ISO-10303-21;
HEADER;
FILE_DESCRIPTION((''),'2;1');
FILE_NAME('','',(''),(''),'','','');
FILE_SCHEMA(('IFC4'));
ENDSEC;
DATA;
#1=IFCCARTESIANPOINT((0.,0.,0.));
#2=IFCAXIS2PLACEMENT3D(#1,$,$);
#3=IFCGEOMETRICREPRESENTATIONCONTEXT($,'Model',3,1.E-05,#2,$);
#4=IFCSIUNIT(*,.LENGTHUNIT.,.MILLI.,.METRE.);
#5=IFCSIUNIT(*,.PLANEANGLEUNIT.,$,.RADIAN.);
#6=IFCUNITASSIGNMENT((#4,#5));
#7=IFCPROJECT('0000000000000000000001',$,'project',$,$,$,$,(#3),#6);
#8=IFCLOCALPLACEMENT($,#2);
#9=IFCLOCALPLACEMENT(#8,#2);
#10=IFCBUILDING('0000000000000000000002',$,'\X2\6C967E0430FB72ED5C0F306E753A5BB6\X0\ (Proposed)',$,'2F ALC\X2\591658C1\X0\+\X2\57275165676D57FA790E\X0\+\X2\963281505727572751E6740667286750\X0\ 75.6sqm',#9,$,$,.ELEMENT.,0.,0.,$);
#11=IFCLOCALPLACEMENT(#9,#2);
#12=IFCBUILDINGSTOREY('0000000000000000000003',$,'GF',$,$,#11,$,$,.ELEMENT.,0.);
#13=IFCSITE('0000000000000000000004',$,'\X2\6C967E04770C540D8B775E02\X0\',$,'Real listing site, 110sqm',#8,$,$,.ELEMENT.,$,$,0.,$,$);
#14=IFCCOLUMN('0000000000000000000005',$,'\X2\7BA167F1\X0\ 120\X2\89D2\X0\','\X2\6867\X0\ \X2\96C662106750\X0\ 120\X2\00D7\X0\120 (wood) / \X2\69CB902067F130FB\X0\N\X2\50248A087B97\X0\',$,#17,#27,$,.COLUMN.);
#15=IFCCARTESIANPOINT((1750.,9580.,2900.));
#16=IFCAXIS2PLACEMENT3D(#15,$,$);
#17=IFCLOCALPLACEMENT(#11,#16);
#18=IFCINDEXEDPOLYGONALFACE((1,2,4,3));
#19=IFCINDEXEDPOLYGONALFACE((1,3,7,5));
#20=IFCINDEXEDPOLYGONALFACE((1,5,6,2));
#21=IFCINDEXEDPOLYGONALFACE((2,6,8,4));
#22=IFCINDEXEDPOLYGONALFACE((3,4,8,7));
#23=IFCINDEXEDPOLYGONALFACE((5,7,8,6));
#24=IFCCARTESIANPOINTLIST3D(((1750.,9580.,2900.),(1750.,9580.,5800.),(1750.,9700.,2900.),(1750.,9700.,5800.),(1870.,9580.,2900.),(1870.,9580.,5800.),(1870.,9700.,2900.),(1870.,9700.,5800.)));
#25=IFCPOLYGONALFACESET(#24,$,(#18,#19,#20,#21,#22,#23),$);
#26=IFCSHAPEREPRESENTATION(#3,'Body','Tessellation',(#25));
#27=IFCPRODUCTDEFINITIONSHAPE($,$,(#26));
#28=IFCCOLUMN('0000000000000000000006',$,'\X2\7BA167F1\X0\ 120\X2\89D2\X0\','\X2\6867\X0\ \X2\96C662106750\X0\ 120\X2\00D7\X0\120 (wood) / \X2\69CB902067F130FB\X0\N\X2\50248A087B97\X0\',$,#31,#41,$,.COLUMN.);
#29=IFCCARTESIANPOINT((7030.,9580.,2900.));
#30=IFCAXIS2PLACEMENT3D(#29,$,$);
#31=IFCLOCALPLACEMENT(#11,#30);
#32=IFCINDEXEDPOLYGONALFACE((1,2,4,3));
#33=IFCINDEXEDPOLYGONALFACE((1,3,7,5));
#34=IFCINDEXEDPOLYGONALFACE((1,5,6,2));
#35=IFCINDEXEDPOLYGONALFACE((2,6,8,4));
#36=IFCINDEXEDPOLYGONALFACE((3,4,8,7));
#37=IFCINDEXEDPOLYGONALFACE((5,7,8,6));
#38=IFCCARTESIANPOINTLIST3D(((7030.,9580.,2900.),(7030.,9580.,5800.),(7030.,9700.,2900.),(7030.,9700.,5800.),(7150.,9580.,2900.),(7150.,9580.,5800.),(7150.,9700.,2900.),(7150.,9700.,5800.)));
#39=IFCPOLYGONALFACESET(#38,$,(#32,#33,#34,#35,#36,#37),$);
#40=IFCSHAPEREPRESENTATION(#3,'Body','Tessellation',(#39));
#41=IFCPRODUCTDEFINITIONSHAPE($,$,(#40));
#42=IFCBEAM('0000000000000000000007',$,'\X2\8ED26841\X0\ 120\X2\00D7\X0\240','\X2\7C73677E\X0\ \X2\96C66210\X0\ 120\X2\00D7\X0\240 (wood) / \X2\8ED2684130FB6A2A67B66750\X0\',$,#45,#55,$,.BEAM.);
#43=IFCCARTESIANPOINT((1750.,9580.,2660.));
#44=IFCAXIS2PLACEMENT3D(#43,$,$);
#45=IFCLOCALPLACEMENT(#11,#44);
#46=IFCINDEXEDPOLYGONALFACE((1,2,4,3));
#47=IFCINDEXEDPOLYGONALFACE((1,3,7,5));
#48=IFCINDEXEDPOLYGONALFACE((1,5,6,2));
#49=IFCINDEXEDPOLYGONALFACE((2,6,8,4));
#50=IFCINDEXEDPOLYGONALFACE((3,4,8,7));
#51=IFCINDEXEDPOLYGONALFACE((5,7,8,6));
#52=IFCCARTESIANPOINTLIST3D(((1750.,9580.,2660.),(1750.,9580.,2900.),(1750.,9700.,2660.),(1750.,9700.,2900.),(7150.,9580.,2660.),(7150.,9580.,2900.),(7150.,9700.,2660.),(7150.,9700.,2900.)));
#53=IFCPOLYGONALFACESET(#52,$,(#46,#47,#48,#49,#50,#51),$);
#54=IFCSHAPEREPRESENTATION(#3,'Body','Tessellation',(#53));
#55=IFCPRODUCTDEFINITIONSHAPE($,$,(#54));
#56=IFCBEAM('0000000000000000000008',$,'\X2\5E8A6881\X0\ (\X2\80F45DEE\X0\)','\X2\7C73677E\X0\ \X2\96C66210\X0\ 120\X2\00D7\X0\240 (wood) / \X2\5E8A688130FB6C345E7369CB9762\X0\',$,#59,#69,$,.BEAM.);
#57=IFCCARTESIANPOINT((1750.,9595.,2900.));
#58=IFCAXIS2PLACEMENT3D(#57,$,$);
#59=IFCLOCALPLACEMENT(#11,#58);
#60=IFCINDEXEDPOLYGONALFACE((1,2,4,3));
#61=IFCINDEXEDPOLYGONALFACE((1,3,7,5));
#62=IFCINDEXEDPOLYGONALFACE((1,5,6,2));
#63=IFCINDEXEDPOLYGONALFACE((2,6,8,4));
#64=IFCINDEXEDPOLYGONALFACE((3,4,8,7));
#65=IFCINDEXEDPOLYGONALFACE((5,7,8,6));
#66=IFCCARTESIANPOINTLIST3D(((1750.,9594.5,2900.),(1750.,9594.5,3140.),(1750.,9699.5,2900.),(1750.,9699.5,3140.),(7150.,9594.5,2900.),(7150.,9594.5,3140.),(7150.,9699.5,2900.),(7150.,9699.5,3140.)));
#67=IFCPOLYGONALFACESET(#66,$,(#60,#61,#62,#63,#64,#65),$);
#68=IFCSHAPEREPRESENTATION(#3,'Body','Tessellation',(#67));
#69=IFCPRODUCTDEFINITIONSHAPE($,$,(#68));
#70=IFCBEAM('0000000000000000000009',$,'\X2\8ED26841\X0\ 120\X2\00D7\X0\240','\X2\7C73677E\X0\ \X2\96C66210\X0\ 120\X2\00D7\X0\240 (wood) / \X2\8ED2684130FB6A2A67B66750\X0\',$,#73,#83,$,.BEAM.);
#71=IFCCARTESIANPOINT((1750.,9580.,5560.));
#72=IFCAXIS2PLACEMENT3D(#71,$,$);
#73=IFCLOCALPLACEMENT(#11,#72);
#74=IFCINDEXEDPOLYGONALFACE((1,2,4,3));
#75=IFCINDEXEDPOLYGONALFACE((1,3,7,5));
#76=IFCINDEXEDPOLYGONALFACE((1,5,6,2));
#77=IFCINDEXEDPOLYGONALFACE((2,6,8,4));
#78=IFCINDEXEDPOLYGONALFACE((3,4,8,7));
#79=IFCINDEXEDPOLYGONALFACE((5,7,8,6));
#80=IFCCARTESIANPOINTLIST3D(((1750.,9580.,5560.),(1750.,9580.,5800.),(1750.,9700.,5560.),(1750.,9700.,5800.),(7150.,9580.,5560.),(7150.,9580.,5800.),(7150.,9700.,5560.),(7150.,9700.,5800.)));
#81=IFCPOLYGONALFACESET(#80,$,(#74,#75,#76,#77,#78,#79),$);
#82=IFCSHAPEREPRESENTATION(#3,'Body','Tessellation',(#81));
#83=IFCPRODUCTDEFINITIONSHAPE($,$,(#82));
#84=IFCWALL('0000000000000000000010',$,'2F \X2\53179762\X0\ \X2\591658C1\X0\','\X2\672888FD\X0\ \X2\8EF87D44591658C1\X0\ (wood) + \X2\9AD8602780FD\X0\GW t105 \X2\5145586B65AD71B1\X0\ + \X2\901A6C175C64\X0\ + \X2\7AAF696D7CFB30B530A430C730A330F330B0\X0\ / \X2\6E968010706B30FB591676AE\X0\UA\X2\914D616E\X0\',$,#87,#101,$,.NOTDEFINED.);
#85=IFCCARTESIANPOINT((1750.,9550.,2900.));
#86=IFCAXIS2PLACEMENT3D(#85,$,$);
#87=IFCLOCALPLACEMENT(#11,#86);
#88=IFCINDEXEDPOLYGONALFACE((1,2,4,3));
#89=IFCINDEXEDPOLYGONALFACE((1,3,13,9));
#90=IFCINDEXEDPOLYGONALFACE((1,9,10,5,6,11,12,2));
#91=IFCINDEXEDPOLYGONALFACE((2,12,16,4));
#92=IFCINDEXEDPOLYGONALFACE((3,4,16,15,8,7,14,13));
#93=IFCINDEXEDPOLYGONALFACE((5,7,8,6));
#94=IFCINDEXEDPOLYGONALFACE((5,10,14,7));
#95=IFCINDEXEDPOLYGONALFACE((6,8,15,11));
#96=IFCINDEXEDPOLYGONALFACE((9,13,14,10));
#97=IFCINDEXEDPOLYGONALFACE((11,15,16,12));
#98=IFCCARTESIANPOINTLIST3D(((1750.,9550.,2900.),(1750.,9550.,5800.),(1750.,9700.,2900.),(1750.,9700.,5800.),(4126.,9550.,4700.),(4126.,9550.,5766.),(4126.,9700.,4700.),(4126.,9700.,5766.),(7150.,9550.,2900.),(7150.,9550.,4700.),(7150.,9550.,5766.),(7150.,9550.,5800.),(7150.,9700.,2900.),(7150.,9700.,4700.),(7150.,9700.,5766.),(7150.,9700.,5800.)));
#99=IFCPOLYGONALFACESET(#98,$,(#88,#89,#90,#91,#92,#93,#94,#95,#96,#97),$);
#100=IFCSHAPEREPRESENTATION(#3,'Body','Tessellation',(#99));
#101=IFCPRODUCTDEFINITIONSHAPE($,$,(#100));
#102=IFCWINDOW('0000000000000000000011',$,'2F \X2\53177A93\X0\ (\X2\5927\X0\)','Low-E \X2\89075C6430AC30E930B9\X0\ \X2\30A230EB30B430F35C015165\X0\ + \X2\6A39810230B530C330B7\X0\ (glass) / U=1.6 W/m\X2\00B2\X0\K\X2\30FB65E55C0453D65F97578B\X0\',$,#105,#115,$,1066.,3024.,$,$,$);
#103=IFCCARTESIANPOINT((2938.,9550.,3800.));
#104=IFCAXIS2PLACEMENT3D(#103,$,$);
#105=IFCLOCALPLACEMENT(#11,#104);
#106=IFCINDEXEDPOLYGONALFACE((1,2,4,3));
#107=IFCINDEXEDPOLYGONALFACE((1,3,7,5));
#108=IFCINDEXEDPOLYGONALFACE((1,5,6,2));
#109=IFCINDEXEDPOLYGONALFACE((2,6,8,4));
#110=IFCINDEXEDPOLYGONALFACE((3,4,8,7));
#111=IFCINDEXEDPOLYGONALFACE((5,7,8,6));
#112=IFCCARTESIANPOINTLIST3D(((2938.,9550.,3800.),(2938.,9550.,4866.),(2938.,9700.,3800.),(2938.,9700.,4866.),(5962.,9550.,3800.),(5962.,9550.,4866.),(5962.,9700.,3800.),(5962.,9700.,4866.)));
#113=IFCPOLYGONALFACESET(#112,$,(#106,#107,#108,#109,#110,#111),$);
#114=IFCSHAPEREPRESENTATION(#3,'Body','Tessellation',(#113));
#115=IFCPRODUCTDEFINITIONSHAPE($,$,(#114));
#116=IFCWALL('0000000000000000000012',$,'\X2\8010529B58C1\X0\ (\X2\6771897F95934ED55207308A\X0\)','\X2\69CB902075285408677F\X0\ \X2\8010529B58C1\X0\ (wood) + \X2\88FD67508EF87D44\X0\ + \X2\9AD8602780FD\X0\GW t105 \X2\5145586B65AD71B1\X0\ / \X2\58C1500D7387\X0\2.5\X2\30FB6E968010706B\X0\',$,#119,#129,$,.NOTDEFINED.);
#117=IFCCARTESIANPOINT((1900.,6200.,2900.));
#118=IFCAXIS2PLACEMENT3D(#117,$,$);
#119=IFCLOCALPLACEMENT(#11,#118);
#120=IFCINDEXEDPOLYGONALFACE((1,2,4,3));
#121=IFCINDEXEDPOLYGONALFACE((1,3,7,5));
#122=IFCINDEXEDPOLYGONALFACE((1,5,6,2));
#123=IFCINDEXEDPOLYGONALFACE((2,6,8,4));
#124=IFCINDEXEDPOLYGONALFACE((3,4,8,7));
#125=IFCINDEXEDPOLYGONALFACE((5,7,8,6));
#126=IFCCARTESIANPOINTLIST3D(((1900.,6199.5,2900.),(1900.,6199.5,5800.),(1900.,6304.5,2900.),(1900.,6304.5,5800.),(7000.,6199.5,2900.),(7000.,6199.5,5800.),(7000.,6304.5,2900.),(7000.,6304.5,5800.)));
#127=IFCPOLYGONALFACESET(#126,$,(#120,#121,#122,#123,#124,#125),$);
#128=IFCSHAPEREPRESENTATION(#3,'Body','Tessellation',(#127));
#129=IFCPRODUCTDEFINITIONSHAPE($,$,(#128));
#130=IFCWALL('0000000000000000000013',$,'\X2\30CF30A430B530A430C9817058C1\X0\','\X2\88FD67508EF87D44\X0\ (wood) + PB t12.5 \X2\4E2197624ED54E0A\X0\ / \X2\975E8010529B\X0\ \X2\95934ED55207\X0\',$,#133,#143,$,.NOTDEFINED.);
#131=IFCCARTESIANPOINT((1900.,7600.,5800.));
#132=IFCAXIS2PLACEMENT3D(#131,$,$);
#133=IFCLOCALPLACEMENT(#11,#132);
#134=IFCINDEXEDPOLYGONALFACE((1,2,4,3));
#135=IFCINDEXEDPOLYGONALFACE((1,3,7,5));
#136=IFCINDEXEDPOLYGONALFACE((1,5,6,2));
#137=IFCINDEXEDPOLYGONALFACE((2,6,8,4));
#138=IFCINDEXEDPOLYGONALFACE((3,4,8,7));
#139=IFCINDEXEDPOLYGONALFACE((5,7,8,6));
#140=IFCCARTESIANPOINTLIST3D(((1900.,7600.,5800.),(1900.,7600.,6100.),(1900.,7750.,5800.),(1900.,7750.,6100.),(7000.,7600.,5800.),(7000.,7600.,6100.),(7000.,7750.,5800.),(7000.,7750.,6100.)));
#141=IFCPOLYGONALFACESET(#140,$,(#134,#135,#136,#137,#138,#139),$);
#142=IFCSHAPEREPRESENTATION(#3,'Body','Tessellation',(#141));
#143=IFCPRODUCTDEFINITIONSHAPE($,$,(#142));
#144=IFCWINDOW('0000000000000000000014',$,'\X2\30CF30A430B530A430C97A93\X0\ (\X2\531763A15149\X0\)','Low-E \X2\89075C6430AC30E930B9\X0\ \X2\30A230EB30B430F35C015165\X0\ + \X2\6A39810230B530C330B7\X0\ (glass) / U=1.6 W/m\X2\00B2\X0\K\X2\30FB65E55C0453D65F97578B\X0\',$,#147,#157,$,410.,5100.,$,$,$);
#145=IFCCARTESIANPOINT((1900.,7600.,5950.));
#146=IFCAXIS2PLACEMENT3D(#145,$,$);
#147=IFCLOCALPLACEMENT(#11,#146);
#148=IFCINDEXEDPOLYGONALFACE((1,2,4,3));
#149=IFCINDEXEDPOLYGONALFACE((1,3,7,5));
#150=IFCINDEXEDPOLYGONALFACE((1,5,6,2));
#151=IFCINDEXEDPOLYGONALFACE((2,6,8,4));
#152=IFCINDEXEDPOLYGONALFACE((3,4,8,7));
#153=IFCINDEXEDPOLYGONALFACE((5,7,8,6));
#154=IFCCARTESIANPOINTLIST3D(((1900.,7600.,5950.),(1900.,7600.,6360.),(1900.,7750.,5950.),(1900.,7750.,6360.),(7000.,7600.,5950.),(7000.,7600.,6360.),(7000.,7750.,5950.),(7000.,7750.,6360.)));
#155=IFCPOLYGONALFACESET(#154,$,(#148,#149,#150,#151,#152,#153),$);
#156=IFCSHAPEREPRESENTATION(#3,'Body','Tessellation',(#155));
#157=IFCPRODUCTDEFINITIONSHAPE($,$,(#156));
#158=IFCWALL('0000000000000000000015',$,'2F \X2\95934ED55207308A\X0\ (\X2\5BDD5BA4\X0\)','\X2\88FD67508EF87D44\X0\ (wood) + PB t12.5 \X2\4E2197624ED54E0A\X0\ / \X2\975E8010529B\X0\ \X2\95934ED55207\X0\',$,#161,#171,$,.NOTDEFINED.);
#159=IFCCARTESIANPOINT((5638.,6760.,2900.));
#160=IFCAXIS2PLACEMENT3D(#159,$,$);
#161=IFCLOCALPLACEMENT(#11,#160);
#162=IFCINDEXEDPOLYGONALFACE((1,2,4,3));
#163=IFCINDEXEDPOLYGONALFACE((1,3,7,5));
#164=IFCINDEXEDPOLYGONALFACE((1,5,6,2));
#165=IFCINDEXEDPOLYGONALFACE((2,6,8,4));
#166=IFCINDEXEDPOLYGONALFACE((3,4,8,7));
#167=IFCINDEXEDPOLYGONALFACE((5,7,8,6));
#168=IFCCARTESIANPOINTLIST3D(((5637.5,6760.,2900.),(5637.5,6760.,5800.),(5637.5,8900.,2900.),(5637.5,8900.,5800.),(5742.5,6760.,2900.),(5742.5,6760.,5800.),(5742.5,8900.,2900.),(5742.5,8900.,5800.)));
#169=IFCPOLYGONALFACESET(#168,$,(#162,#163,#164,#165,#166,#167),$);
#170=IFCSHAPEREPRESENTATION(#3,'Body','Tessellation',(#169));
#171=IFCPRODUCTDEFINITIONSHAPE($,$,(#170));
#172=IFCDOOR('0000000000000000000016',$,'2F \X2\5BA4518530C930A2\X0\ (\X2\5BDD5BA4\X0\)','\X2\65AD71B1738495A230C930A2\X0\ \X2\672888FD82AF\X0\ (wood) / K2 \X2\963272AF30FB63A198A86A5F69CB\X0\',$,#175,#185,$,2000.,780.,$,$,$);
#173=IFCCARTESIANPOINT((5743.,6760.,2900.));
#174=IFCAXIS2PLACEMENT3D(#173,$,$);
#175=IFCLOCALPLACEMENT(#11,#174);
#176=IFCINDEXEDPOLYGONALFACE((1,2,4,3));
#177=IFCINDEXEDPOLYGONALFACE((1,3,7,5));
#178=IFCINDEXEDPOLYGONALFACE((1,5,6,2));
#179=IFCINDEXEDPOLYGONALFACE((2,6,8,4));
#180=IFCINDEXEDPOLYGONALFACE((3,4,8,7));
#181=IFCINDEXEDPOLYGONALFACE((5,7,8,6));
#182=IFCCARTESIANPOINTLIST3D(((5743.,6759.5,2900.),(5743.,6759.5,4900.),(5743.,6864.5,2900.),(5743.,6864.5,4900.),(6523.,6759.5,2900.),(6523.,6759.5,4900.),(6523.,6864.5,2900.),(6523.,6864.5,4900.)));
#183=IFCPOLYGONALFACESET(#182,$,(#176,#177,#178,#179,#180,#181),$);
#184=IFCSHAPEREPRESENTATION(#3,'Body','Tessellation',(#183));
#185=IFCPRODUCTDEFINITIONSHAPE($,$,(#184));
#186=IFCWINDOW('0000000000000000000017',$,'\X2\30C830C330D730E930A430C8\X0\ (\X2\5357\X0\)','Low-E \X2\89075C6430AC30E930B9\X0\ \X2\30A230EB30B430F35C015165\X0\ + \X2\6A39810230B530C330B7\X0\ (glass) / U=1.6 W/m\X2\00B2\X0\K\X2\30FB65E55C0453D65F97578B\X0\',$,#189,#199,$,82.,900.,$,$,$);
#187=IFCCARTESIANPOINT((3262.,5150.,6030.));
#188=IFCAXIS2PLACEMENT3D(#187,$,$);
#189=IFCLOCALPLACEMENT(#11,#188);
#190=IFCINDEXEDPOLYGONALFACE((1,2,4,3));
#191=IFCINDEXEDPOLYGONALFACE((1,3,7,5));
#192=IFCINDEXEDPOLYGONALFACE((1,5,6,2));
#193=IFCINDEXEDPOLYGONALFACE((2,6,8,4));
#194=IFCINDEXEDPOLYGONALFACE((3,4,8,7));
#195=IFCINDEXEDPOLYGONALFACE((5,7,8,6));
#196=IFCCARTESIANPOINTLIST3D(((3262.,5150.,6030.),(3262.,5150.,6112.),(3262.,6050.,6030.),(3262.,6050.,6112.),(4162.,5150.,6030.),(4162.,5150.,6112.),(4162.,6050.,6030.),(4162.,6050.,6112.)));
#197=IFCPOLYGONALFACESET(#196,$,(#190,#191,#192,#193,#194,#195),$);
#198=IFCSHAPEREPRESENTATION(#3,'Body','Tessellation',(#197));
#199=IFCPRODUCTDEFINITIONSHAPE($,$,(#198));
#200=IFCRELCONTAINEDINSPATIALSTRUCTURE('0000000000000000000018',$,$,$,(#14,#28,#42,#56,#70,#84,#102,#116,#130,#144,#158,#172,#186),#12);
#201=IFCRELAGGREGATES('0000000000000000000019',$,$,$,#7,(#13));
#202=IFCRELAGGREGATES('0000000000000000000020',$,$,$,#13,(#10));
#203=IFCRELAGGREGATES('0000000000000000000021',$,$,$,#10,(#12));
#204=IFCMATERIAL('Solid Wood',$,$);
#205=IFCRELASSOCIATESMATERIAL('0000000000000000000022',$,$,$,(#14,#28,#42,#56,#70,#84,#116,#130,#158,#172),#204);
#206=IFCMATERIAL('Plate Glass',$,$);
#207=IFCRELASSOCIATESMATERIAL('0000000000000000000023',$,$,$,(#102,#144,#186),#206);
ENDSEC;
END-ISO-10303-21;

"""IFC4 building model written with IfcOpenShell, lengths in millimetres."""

from ifc_helpers import new_model, si_unit, frame, frame_2d, origin, place, context, project, spatial, rectangle, extrude, material, element, fill, save


model = new_model("IFC4")

# Units and contexts
model_context = context("Model", 3, precision=1e-05, world=origin())
ifc_project = project(units=[si_unit("LENGTHUNIT", "METRE", prefix="MILLI"), si_unit("PLANEANGLEUNIT", "RADIAN")], contexts=[model_context])

# Site, building, storey
site_placement = place(None, origin())
site = spatial("IfcSite", under=ifc_project, at=site_placement, Name="沖縄県名護市", ObjectType="Real listing site, 110sqm", CompositionType="ELEMENT", RefElevation=0.0)
building_placement = place(site_placement, origin())
building = spatial("IfcBuilding", under=site, at=building_placement, Name="沖縄・狭小の町家 (Proposed)", ObjectType="2F ALC外壁+圧入杭基礎+防腐圧圧処理木材 75.6sqm", CompositionType="ELEMENT", ElevationOfRefHeight=0.0, ElevationOfTerrain=0.0)
storey_placement = place(building_placement, origin())
storey = spatial("IfcBuildingStorey", under=building, at=storey_placement, Name="GF", CompositionType="ELEMENT", Elevation=0.0)

# Columns
ifc_material_1 = material(Name="Solid Wood")
column_1_placement = place(storey_placement, frame((1750.0, 9580.0, 2900.0)))
element("IfcColumn", 1, at=column_1_placement, inside=storey, material=ifc_material_1, Name="管柱 120角", Description="桧 集成材 120×120 (wood) / 構造柱・N値計算", PredefinedType="COLUMN", context=model_context, shape_type="SweptSolid", body=[
    extrude(rectangle(XDim=120.0, YDim=120.0, at=frame_2d((60.0, 60.0))), frame((1750.0, 9580.0, 2900.0)), (0.0, 0.0, 1.0), 2900.0),
])
column_2_placement = place(storey_placement, frame((7030.0, 9580.0, 2900.0)))
element("IfcColumn", 2, at=column_2_placement, inside=storey, material=ifc_material_1, Name="管柱 120角", Description="桧 集成材 120×120 (wood) / 構造柱・N値計算", PredefinedType="COLUMN", context=model_context, shape_type="SweptSolid", body=[
    extrude(rectangle(XDim=120.0, YDim=120.0, at=frame_2d((60.0, 60.0))), frame((7030.0, 9580.0, 2900.0)), (0.0, 0.0, 1.0), 2900.0),
])

# Beams
beam_1_placement = place(storey_placement, frame((1750.0, 9580.0, 2660.0)))
element("IfcBeam", 3, at=beam_1_placement, inside=storey, material=ifc_material_1, Name="軒桁 120×240", Description="米松 集成 120×240 (wood) / 軒桁・横架材", PredefinedType="BEAM", context=model_context, shape_type="SweptSolid", body=[
    extrude(rectangle(XDim=5400.0, YDim=120.0, at=frame_2d((2700.0, 60.0))), frame((1750.0, 9580.0, 2660.0)), (0.0, 0.0, 1.0), 240.0),
])
beam_2_placement = place(storey_placement, frame((1750.0, 9595.0, 2900.0)))
element("IfcBeam", 4, at=beam_2_placement, inside=storey, material=ifc_material_1, Name="床梁 (胴差)", Description="米松 集成 120×240 (wood) / 床梁・水平構面", PredefinedType="BEAM", context=model_context, shape_type="SweptSolid", body=[
    extrude(rectangle(XDim=5400.0, YDim=105.0, at=frame_2d((2700.0, 52.0))), frame((1750.0, 9595.0, 2900.0)), (0.0, 0.0, 1.0), 240.0),
])
beam_3_placement = place(storey_placement, frame((1750.0, 9580.0, 5560.0)))
element("IfcBeam", 5, at=beam_3_placement, inside=storey, material=ifc_material_1, Name="軒桁 120×240", Description="米松 集成 120×240 (wood) / 軒桁・横架材", PredefinedType="BEAM", context=model_context, shape_type="SweptSolid", body=[
    extrude(rectangle(XDim=5400.0, YDim=120.0, at=frame_2d((2700.0, 60.0))), frame((1750.0, 9580.0, 5560.0)), (0.0, 0.0, 1.0), 240.0),
])

# Wall, opening, window
wall_1_placement = place(storey_placement, frame((1750.0, 9550.0, 2900.0)))
wall_1 = element("IfcWall", 6, at=wall_1_placement, inside=storey, material=ifc_material_1, Name="2F 北面 外壁", Description="木製 軸組外壁 (wood) + 高性能GW t105 充填断熱 + 通気層 + 窯業系サイディング / 準耐火・外皮UA配慮", PredefinedType="NOTDEFINED", context=model_context, shape_type="SweptSolid", body=[
    extrude(rectangle(XDim=5400.0, YDim=150.0, at=frame_2d((2700.0, 75.0))), frame((1750.0, 9550.0, 2900.0)), (0.0, 0.0, 1.0), 2900.0),
])
opening_1_placement = place(storey_placement, frame((2938.0, 9550.0, 3800.0)))
opening_1 = element("IfcOpeningElement", 7, at=opening_1_placement, cuts=wall_1, PredefinedType="NOTDEFINED", context=model_context, shape_type="SweptSolid", body=[
    extrude(rectangle(XDim=3024.0, YDim=150.0, at=frame_2d((1512.0, 75.0))), frame((2938.0, 9550.0, 3800.0)), (0.0, 0.0, 1.0), 1066.0),
])
ifc_material_2 = material(Name="Plate Glass")
window_1_placement = place(storey_placement, frame((2938.0, 9550.0, 3800.0)))
window_1 = element("IfcWindow", 8, at=window_1_placement, inside=storey, material=ifc_material_2, Name="2F 北窓 (大)", Description="Low-E 複層ガラス アルゴン封入 + 樹脂サッシ (glass) / U=1.6 W/m²K・日射取得型", OverallHeight=1066.0, OverallWidth=3024.0, context=model_context, shape_type="SweptSolid", body=[
    extrude(rectangle(XDim=3024.0, YDim=150.0, at=frame_2d((1512.0, 75.0))), frame((2938.0, 9550.0, 3800.0)), (0.0, 0.0, 1.0), 1066.0),
])
fill(opening_1, window_1)

# Wall
wall_2_placement = place(storey_placement, frame((1900.0, 6200.0, 2900.0)))
element("IfcWall", 9, at=wall_2_placement, inside=storey, material=ifc_material_1, Name="耐力壁 (東西間仕切り)", Description="構造用合板 耐力壁 (wood) + 製材軸組 + 高性能GW t105 充填断熱 / 壁倍率2.5・準耐火", PredefinedType="NOTDEFINED", context=model_context, shape_type="SweptSolid", body=[
    extrude(rectangle(XDim=5100.0, YDim=105.0, at=frame_2d((2550.0, 52.0))), frame((1900.0, 6200.0, 2900.0)), (0.0, 0.0, 1.0), 2900.0),
])

# Wall, opening, window
wall_3_placement = place(storey_placement, frame((1900.0, 7600.0, 5800.0)))
wall_3 = element("IfcWall", 10, at=wall_3_placement, inside=storey, material=ifc_material_1, Name="ハイサイド腰壁", Description="製材軸組 (wood) + PB t12.5 両面仕上 / 非耐力 間仕切", PredefinedType="NOTDEFINED", context=model_context, shape_type="SweptSolid", body=[
    extrude(rectangle(XDim=5100.0, YDim=150.0, at=frame_2d((2550.0, 75.0))), frame((1900.0, 7600.0, 5800.0)), (0.0, 0.0, 1.0), 700.0),
])
opening_2_placement = place(storey_placement, frame((1900.0, 7600.0, 5950.0)))
opening_2 = element("IfcOpeningElement", 11, at=opening_2_placement, cuts=wall_3, PredefinedType="NOTDEFINED", context=model_context, shape_type="SweptSolid", body=[
    extrude(rectangle(XDim=5100.0, YDim=150.0, at=frame_2d((2550.0, 75.0))), frame((1900.0, 7600.0, 5950.0)), (0.0, 0.0, 1.0), 410.0),
])
window_2_placement = place(storey_placement, frame((1900.0, 7600.0, 5950.0)))
window_2 = element("IfcWindow", 12, at=window_2_placement, inside=storey, material=ifc_material_2, Name="ハイサイド窓 (北採光)", Description="Low-E 複層ガラス アルゴン封入 + 樹脂サッシ (glass) / U=1.6 W/m²K・日射取得型", OverallHeight=410.0, OverallWidth=5100.0, context=model_context, shape_type="SweptSolid", body=[
    extrude(rectangle(XDim=5100.0, YDim=150.0, at=frame_2d((2550.0, 75.0))), frame((1900.0, 7600.0, 5950.0)), (0.0, 0.0, 1.0), 410.0),
])
fill(opening_2, window_2)

# Wall
wall_4_placement = place(storey_placement, frame((5638.0, 6760.0, 2900.0)))
element("IfcWall", 13, at=wall_4_placement, inside=storey, material=ifc_material_1, Name="2F 間仕切り (寝室)", Description="製材軸組 (wood) + PB t12.5 両面仕上 / 非耐力 間仕切", PredefinedType="NOTDEFINED", context=model_context, shape_type="SweptSolid", body=[
    extrude(rectangle(XDim=105.0, YDim=2140.0, at=frame_2d((52.0, 1070.0))), frame((5638.0, 6760.0, 2900.0)), (0.0, 0.0, 1.0), 2900.0),
])

# Door
door_placement = place(storey_placement, frame((5743.0, 6760.0, 2900.0)))
element("IfcDoor", 14, at=door_placement, inside=storey, material=ifc_material_1, Name="2F 室内ドア (寝室)", Description="断熱玄関ドア 木製芯 (wood) / K2 防犯・採風機構", OverallHeight=2000.0, OverallWidth=780.0, context=model_context, shape_type="SweptSolid", body=[
    extrude(rectangle(XDim=780.0, YDim=105.0, at=frame_2d((390.0, 52.0))), frame((5743.0, 6760.0, 2900.0)), (0.0, 0.0, 1.0), 2000.0),
])

# Window
window_3_placement = place(storey_placement, frame((3262.0, 5150.0, 6030.0)))
element("IfcWindow", 15, at=window_3_placement, inside=storey, material=ifc_material_2, Name="トップライト (南)", Description="Low-E 複層ガラス アルゴン封入 + 樹脂サッシ (glass) / U=1.6 W/m²K・日射取得型", OverallHeight=82.0, OverallWidth=900.0, context=model_context, shape_type="SweptSolid", body=[
    extrude(rectangle(XDim=900.0, YDim=900.0, at=frame_2d((450.0, 450.0))), frame((3262.0, 5150.0, 6030.0)), (0.0, 0.0, 1.0), 82.0),
])

save(model, "model.ifc")
